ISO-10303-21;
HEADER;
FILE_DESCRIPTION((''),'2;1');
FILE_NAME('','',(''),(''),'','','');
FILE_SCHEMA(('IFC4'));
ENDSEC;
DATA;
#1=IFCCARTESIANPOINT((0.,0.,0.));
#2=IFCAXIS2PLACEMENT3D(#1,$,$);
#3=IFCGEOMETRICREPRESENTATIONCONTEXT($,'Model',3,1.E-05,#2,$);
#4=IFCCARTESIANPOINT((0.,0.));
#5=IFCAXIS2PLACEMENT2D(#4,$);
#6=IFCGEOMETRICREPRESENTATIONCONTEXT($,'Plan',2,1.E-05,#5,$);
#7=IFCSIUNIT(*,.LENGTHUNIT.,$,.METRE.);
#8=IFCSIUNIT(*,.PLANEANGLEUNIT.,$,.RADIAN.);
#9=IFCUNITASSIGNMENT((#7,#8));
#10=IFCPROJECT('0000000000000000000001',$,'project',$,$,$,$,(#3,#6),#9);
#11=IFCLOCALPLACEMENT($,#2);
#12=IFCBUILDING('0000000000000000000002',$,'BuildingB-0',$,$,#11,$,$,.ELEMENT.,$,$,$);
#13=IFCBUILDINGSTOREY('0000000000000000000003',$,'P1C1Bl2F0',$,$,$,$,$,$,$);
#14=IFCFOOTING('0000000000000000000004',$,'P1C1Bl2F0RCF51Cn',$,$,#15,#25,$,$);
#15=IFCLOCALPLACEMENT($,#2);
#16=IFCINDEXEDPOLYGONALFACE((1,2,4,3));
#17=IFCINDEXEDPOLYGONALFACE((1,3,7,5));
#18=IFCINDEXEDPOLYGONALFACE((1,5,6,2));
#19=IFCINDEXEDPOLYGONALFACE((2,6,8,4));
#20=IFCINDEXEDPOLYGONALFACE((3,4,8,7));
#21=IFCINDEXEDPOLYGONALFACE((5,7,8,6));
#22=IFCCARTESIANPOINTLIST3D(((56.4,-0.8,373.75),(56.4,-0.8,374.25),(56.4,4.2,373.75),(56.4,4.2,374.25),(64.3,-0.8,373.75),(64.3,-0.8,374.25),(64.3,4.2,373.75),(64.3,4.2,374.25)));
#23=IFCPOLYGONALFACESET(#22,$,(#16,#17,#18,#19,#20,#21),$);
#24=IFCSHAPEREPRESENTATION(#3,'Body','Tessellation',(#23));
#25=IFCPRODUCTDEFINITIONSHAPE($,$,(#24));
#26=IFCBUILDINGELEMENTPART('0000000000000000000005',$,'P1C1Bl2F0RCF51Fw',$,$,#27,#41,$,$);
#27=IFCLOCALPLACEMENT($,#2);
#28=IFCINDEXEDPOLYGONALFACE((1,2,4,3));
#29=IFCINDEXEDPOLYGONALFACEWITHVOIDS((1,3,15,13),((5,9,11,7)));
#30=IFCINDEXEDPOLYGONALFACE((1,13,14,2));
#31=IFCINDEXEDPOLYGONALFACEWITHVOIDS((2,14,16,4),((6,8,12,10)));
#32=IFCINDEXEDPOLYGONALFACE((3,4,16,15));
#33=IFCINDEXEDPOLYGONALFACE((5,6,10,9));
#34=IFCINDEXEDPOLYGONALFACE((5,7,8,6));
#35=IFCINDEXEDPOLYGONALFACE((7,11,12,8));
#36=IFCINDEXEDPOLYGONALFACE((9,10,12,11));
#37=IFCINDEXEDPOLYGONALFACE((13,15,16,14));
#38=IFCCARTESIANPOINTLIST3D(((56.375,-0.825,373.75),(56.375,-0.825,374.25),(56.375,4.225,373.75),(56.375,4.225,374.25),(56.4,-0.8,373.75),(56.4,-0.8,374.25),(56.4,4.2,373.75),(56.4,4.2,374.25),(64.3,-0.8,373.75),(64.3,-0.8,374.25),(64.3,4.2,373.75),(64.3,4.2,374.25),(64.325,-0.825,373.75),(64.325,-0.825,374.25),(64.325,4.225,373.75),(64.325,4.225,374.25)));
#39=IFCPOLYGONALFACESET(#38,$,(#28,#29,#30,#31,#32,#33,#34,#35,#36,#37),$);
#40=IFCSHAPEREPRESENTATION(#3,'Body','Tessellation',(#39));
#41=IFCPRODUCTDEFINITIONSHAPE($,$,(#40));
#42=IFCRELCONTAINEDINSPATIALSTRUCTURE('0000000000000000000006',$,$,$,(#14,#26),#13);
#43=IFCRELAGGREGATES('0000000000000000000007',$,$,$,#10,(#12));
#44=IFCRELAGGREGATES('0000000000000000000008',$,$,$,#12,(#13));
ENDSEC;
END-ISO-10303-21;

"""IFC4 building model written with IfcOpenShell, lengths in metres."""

from ifc_helpers import new_model, si_unit, origin, origin_2d, place, context, project, spatial, polyline, outline, extrude, element, save


model = new_model("IFC4")

# Units and contexts
model_context = context("Model", 3, precision=1e-05, world=origin())
plan_context = context("Plan", 2, precision=1e-05, world=origin_2d())
ifc_project = project(units=[si_unit("LENGTHUNIT", "METRE"), si_unit("PLANEANGLEUNIT", "RADIAN")], contexts=[model_context, plan_context])

# Building, storey
building_placement = place(None, origin())
building = spatial("IfcBuilding", under=ifc_project, at=building_placement, Name="BuildingB-0", CompositionType="ELEMENT")
storey = spatial("IfcBuildingStorey", under=building, Name="P1C1Bl2F0")

# Footing
element("IfcFooting", 1, inside=storey, Name="P1C1Bl2F0RCF51Cn", context=model_context, shape_type="SweptSolid", body=[
    extrude(outline(polyline([(64.3, 4.2, 373.75), (56.4, 4.2, 373.75), (56.4, -0.8, 373.75), (64.3, -0.8, 373.75), (64.3, 4.2, 373.75)])), None, (0.0, 0.0, 1.0), 0.5),
])

# Building element part, opening
building_element_part = element("IfcBuildingElementPart", 2, inside=storey, Name="P1C1Bl2F0RCF51Fw", context=model_context, shape_type="SweptSolid", body=[
    extrude(outline(polyline([(64.325, 4.225, 373.75), (56.375, 4.225, 373.75), (56.375, -0.825, 373.75), (64.325, -0.825, 373.75), (64.325, 4.225, 373.75)])), None, (0.0, 0.0, 1.0), 0.5),
])
element("IfcOpeningElement", 3, inside=storey, cuts=building_element_part, context=model_context, shape_type="SweptSolid", body=[
    extrude(outline(polyline([(64.3, 4.2, 373.75), (56.4, 4.2, 373.75), (56.4, -0.8, 373.75), (64.3, -0.8, 373.75), (64.3, 4.2, 373.75)])), None, (0.0, 0.0, 1.0), 0.5),
])

save(model, "model.ifc")
